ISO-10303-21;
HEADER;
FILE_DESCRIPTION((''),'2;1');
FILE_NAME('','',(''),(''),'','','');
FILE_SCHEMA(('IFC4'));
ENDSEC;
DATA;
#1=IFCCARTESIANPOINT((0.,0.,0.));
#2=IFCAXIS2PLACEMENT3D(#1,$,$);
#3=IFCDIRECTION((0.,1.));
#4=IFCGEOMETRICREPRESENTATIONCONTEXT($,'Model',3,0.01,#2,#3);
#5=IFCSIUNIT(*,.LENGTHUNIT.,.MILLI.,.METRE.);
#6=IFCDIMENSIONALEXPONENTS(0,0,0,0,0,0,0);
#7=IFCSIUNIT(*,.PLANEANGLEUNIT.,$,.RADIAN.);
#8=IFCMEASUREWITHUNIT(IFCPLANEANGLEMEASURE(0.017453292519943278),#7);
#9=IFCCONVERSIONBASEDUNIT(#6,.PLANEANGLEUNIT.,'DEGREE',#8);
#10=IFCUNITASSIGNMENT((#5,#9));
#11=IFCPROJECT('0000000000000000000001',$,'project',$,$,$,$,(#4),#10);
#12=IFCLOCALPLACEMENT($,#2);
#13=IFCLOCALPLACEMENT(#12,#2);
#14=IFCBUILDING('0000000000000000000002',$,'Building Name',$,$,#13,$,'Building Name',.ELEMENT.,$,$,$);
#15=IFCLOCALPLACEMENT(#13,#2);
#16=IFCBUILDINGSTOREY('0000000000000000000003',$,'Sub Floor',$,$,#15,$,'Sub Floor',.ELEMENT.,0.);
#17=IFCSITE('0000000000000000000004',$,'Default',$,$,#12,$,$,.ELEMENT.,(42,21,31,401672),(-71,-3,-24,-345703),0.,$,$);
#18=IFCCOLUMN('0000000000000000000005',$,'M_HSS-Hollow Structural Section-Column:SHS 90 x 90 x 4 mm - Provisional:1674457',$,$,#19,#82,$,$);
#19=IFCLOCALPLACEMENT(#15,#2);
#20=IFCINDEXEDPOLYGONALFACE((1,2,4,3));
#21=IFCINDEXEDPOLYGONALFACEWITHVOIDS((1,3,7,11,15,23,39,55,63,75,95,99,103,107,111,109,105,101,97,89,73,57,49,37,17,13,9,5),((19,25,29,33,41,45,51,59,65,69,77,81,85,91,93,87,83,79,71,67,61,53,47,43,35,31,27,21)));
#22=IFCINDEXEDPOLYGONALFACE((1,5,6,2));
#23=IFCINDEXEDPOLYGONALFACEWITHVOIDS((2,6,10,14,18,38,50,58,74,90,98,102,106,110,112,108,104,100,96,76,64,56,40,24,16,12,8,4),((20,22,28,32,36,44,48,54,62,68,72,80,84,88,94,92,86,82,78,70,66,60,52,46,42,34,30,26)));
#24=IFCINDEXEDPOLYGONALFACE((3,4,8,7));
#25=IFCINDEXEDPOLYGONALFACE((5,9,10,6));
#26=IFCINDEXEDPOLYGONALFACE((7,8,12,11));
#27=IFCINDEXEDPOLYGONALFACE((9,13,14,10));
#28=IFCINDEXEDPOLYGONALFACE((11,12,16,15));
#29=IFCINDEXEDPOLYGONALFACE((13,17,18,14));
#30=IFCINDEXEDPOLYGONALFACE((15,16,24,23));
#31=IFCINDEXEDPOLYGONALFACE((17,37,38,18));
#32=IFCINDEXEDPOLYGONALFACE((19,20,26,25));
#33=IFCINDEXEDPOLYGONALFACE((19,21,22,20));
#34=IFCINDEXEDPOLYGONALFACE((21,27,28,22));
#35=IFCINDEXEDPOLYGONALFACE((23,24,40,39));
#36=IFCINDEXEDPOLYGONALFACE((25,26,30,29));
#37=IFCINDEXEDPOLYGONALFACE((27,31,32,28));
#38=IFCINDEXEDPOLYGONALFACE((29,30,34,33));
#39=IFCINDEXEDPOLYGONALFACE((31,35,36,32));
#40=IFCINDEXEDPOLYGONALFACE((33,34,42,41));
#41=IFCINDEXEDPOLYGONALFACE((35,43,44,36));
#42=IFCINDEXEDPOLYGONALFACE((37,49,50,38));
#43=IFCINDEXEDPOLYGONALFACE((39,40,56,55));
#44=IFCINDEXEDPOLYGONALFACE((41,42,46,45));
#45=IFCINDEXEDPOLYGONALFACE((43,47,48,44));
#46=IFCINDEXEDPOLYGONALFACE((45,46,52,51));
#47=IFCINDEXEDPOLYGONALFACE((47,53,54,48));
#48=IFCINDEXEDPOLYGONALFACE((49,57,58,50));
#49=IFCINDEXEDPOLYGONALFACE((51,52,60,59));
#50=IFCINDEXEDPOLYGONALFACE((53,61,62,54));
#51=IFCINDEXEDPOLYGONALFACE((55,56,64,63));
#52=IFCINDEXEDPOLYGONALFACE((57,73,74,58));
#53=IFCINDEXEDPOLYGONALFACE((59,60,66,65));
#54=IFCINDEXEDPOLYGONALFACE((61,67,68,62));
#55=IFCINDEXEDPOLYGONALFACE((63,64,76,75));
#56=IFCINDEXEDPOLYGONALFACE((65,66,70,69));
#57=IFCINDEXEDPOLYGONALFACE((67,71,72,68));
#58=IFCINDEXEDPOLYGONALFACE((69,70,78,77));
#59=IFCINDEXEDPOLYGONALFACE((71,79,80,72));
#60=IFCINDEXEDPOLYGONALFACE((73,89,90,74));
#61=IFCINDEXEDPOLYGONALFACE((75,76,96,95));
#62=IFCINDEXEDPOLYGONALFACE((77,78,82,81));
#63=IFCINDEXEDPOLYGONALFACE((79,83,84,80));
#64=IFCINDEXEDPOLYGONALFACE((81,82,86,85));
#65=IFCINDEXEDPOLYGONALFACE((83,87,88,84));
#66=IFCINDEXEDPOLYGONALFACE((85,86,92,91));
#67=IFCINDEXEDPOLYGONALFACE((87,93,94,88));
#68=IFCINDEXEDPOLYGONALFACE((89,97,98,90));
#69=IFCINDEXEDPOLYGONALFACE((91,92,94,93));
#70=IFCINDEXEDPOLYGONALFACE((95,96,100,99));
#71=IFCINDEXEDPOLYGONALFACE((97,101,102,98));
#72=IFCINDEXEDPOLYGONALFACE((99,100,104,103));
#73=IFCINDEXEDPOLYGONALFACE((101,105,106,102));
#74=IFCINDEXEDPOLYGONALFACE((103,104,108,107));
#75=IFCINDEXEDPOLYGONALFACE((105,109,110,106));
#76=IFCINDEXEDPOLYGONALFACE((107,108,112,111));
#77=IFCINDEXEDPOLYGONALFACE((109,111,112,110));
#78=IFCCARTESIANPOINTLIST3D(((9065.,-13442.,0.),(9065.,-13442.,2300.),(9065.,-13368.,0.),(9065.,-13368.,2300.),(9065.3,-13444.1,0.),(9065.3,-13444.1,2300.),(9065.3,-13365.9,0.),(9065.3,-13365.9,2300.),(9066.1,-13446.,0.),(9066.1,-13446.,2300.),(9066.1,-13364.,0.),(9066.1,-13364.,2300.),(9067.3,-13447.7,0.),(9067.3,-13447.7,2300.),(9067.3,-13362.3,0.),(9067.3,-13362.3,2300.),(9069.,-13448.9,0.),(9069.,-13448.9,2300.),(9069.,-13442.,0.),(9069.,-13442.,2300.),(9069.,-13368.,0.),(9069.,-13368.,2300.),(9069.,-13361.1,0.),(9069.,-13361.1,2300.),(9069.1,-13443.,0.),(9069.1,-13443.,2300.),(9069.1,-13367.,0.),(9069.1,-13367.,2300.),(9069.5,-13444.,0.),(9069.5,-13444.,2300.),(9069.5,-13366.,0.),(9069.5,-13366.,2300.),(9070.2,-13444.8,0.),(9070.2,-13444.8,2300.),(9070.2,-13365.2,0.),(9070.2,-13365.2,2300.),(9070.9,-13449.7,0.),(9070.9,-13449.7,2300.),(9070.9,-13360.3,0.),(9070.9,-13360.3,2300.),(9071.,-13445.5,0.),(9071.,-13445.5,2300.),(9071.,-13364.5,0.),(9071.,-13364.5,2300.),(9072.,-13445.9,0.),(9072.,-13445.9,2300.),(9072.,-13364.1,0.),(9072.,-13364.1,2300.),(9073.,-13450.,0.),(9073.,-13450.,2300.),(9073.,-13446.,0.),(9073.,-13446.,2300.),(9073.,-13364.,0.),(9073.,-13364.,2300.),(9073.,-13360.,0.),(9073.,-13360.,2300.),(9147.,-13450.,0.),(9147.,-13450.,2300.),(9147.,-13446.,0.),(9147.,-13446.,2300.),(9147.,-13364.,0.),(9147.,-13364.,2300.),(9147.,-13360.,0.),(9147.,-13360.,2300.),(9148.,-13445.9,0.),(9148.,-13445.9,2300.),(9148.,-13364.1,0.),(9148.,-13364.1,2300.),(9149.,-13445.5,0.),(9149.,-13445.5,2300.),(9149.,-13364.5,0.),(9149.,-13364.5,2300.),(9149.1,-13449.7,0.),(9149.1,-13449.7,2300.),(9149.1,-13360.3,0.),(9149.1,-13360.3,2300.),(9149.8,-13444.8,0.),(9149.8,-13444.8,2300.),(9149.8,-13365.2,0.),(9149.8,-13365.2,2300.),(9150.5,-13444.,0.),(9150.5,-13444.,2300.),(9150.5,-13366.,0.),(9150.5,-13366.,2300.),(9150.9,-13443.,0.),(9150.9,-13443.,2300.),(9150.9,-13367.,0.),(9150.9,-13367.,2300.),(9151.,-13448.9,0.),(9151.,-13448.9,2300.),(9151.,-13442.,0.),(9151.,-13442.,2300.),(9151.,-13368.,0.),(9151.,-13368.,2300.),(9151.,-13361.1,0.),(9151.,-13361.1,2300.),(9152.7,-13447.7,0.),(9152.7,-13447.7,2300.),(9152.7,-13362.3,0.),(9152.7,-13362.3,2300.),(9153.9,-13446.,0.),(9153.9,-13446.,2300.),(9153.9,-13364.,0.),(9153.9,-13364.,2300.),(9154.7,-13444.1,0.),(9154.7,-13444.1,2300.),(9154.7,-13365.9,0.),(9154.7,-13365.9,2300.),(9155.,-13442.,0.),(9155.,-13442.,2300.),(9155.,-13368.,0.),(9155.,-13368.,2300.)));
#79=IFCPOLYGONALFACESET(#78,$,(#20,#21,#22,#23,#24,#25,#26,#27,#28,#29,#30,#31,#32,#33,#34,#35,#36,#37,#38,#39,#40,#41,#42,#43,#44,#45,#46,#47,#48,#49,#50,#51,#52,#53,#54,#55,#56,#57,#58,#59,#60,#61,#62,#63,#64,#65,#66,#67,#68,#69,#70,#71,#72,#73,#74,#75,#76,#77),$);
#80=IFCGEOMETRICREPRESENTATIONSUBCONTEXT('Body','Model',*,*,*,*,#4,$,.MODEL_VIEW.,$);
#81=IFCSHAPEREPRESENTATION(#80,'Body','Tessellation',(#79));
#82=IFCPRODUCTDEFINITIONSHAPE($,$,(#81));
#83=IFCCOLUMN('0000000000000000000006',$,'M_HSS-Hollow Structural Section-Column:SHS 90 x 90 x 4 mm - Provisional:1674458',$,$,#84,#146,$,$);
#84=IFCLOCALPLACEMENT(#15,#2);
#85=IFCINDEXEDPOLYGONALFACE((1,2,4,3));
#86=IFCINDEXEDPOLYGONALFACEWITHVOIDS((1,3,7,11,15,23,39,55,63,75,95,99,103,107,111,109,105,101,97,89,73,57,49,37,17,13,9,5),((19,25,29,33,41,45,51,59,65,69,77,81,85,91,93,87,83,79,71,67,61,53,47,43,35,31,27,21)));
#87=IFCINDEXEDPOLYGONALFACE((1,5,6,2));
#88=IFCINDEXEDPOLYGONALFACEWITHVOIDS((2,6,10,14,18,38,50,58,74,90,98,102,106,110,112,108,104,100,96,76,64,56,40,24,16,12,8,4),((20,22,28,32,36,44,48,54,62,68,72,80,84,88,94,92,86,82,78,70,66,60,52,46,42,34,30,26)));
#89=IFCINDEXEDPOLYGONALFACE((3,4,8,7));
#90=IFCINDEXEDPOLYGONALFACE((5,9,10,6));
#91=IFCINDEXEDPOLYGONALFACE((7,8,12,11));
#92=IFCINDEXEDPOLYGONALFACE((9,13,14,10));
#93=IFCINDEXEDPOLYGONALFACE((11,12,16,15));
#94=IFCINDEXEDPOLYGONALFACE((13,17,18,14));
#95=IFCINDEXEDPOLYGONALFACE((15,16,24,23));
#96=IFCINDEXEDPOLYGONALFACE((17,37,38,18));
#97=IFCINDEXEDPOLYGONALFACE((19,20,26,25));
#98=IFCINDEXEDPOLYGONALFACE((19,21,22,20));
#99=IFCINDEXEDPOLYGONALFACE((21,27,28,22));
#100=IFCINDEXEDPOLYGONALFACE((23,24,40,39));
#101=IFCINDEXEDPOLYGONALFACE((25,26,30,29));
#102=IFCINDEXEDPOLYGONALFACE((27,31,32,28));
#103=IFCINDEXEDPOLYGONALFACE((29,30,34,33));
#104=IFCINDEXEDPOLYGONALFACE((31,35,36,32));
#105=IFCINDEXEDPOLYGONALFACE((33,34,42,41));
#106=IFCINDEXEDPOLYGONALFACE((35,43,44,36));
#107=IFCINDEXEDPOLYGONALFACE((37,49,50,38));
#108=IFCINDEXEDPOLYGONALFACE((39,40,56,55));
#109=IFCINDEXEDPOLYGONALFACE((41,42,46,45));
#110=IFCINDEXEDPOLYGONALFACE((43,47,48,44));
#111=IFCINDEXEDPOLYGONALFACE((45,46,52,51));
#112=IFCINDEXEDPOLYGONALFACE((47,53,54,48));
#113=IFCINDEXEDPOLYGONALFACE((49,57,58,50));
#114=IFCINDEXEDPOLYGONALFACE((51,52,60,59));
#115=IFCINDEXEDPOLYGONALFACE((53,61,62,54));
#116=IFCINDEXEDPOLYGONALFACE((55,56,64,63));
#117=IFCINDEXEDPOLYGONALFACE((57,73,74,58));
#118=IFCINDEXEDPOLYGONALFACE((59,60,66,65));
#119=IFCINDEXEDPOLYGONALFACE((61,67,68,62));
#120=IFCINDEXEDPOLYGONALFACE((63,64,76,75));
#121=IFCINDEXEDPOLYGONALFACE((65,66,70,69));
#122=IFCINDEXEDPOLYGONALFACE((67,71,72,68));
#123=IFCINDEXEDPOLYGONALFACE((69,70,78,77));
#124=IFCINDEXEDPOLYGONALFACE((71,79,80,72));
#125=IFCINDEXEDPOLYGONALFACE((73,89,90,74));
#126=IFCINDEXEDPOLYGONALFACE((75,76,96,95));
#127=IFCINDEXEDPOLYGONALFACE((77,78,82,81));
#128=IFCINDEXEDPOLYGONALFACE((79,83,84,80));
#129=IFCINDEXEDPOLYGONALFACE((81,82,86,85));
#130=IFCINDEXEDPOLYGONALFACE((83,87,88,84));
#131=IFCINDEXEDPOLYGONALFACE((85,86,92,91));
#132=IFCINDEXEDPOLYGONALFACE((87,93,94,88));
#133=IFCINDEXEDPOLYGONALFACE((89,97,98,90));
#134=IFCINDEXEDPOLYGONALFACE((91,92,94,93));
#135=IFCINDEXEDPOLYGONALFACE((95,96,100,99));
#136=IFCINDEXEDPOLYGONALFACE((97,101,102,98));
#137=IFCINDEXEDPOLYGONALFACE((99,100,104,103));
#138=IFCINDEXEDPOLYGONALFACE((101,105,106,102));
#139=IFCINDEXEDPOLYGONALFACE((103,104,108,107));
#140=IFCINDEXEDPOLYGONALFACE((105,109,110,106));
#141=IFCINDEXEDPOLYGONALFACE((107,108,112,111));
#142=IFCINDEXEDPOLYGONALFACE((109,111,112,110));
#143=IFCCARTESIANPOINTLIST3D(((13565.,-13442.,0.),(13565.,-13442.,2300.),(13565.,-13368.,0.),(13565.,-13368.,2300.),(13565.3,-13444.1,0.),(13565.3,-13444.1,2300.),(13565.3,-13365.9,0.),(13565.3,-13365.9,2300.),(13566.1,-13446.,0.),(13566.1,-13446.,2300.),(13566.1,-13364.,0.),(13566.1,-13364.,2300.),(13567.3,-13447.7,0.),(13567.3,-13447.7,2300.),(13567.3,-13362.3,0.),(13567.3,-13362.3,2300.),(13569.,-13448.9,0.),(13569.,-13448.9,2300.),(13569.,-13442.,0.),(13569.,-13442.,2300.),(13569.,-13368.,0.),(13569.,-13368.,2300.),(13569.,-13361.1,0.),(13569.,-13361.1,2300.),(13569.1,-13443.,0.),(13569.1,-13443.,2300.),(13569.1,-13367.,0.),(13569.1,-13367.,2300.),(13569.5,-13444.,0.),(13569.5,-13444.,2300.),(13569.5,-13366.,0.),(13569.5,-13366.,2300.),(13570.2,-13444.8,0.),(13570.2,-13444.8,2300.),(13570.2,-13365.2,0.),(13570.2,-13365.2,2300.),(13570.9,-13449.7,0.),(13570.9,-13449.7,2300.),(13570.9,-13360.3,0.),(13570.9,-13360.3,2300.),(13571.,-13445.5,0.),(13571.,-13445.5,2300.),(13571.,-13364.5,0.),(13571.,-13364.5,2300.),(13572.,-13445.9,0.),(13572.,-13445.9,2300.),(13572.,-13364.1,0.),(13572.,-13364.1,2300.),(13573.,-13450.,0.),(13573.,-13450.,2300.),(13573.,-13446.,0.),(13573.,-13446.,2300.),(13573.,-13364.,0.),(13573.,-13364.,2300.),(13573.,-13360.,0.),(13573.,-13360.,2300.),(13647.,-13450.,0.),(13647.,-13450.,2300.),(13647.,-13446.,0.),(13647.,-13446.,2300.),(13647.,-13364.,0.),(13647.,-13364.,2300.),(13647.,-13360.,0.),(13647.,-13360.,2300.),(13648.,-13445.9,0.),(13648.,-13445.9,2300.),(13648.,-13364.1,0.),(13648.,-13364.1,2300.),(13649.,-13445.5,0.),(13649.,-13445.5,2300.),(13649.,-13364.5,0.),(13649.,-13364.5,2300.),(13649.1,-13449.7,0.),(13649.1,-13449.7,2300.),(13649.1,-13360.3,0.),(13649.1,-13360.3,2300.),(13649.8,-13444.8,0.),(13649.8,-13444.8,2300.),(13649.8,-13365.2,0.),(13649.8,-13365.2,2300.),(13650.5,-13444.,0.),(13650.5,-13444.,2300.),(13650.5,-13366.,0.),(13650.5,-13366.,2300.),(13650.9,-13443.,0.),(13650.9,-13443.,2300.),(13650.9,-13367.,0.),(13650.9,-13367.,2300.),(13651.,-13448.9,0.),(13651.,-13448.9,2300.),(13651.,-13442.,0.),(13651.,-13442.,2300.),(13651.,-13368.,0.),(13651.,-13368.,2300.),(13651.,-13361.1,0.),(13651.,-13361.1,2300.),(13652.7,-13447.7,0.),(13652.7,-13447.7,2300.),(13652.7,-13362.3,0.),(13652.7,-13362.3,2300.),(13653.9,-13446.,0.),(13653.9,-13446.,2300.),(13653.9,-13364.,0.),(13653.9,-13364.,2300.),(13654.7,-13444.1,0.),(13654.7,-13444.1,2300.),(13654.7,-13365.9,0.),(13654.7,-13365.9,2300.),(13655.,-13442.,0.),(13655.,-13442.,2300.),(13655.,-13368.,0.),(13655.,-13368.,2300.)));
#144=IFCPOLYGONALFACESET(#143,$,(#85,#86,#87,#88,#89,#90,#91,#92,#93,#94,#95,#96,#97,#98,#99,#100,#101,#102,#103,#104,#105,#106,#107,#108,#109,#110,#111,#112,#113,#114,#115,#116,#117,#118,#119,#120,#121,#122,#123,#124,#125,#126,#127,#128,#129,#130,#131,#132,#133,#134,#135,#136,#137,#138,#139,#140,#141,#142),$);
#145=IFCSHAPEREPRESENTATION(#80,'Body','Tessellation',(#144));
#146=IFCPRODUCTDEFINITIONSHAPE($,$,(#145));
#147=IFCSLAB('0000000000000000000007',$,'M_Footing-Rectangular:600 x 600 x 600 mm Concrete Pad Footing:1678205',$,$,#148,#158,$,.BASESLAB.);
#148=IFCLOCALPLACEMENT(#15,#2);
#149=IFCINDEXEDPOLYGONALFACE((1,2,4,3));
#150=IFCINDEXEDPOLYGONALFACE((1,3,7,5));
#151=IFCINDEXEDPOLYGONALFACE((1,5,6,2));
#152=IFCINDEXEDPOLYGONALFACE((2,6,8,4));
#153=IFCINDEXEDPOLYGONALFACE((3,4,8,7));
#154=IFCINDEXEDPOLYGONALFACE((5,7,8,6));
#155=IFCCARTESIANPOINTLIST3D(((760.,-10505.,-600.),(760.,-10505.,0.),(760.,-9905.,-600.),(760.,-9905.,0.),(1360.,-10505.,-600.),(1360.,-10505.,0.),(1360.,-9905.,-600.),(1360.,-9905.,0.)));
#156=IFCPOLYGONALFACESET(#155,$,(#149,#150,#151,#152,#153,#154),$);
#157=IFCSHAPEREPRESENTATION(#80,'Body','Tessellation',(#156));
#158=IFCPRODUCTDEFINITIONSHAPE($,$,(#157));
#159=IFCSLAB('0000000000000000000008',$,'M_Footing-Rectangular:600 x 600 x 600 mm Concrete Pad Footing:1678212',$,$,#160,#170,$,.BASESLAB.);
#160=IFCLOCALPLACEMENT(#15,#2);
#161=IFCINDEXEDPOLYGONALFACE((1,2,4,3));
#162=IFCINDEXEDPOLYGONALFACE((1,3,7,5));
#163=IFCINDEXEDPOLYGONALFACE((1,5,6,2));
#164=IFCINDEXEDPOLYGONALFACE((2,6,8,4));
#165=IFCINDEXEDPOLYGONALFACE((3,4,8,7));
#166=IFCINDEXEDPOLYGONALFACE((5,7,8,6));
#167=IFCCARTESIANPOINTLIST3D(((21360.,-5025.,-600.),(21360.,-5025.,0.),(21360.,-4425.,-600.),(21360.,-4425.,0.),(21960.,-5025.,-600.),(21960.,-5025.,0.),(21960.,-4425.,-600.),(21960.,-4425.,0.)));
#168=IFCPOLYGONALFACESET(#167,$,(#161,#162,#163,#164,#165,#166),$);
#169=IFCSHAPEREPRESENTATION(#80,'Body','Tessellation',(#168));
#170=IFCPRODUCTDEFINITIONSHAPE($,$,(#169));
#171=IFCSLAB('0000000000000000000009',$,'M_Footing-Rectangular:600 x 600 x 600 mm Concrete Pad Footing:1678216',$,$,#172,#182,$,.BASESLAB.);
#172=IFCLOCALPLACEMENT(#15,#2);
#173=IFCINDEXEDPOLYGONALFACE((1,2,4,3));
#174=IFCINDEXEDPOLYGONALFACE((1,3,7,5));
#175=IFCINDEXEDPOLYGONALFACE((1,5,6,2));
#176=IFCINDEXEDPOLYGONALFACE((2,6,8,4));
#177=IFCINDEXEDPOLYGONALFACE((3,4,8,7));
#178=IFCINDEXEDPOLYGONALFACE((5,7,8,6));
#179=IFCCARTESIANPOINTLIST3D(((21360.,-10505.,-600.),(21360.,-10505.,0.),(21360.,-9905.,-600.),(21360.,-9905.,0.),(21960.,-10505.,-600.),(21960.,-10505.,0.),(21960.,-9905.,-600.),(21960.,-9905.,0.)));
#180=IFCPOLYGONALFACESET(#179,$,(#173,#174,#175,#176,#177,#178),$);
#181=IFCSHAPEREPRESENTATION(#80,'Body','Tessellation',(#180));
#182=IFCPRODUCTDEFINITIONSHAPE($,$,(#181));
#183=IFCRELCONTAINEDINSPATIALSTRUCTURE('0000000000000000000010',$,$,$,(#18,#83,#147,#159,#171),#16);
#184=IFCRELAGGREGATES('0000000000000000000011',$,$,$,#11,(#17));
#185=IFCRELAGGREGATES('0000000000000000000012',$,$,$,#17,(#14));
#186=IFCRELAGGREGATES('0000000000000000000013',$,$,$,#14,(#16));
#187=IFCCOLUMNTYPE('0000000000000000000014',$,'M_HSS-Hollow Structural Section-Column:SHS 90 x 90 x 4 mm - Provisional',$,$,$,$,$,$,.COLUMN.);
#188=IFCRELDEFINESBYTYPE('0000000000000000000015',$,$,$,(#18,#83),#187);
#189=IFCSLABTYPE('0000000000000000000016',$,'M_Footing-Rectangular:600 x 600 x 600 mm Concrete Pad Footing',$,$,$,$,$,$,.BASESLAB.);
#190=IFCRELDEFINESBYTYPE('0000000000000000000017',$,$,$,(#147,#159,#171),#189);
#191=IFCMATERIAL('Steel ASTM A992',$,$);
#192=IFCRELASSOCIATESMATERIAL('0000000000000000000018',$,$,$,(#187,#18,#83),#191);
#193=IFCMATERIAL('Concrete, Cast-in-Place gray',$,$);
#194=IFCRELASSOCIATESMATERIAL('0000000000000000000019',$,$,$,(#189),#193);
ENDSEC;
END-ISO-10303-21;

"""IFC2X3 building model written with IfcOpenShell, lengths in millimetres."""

from ifc_helpers import new_model, entity, si_unit, converted_unit, direction, frame, frame_2d, origin, place, context, subcontext, project, spatial, polyline, circle_curve, parameter, trimmed, segment, composite_curve, rectangle, outline, extrude, source, transform, mapped, material, type_object, type_shapes, element, save


model = new_model("IFC2X3")

# Units and contexts
model_context = context("Model", 3, precision=0.01, world=origin(), true_north=direction((0.0, 1.0)))
body_context = subcontext(model_context, "Body", "Model", "MODEL_VIEW")
ifc_project = project(units=[si_unit("LENGTHUNIT", "METRE", prefix="MILLI"), converted_unit("PLANEANGLEUNIT", "DEGREE", entity("IfcPlaneAngleMeasure", 0.017453292519943278), si_unit("PLANEANGLEUNIT", "RADIAN"), dimensions=[0, 0, 0, 0, 0, 0, 0])], contexts=[model_context])

# Site, building, storey
site_placement = place(None, origin())
site = spatial("IfcSite", under=ifc_project, at=site_placement, Name="Default", CompositionType="ELEMENT", RefLatitude=(42, 21, 31, 401672), RefLongitude=(-71, -3, -24, -345703), RefElevation=0.0)
building_placement = place(site_placement, origin())
building = spatial("IfcBuilding", under=site, at=building_placement, Name="Building Name", LongName="Building Name", CompositionType="ELEMENT")
storey_placement = place(building_placement, origin())
storey = spatial("IfcBuildingStorey", under=building, at=storey_placement, Name="Sub Floor", LongName="Sub Floor", CompositionType="ELEMENT", Elevation=0.0)

# Columns
ifc_material_1 = material(Name="Steel ASTM A992")
column_type = type_object("IfcColumnType", Name="M_HSS-Hollow Structural Section-Column:SHS 90 x 90 x 4 mm - Provisional", PredefinedType="COLUMN", material=ifc_material_1)
shared_shape_1 = source(origin(), body_context, "Body", "SweptSolid", [
    extrude(outline(composite_curve([segment(polyline([(-37.0, -45.0), (37.0, -45.0)]), True, "CONTINUOUS"), segment(trimmed(circle_curve(frame_2d((37.0, -37.0), x_axis=(-1.0, 0.0)), 8.0), [parameter(90.0)], [parameter(180.0)], True, "PARAMETER"), True, "CONTINUOUS"), segment(polyline([(45.0, -37.0), (45.0, 37.0)]), True, "CONTINUOUS"), segment(trimmed(circle_curve(frame_2d((37.0, 37.0), x_axis=(-1.0, 0.0)), 8.0), [parameter(180.0)], [parameter(270.0)], True, "PARAMETER"), True, "CONTINUOUS"), segment(polyline([(37.0, 45.0), (-37.0, 45.0)]), True, "CONTINUOUS"), segment(trimmed(circle_curve(frame_2d((-37.0, 37.0), x_axis=(-1.0, 0.0)), 8.0), [parameter(270.0)], [parameter(360.0)], True, "PARAMETER"), True, "CONTINUOUS"), segment(polyline([(-45.0, 37.0), (-45.0, -37.0)]), True, "CONTINUOUS"), segment(trimmed(circle_curve(frame_2d((-37.0, -37.0), x_axis=(-1.0, 0.0)), 8.0), [parameter(360.0)], [parameter(90.0)], True, "PARAMETER"), True, "CONTINUOUS")], self_intersect=False), holes=[composite_curve([segment(trimmed(circle_curve(frame_2d((-37.0, -37.0), x_axis=(-1.0, 0.0)), 4.0), [parameter(0.0)], [parameter(90.0)], True, "PARAMETER"), False, "CONTINUOUS"), segment(polyline([(-41.0, -37.0), (-41.0, 37.0)]), True, "CONTINUOUS"), segment(trimmed(circle_curve(frame_2d((-37.0, 37.0), x_axis=(-1.0, 0.0)), 4.0), [parameter(270.0)], [parameter(0.0)], True, "PARAMETER"), False, "CONTINUOUS"), segment(polyline([(-37.0, 41.0), (37.0, 41.0)]), True, "CONTINUOUS"), segment(trimmed(circle_curve(frame_2d((37.0, 37.0), x_axis=(-1.0, 0.0)), 4.0), [parameter(180.0)], [parameter(270.0)], True, "PARAMETER"), False, "CONTINUOUS"), segment(polyline([(41.0, 37.0), (41.0, -37.0)]), True, "CONTINUOUS"), segment(trimmed(circle_curve(frame_2d((37.0, -37.0), x_axis=(-1.0, 0.0)), 4.0), [parameter(90.0)], [parameter(180.0)], True, "PARAMETER"), False, "CONTINUOUS"), segment(polyline([(37.0, -41.0), (-37.0, -41.0)]), True, "CONTINUOUS")], self_intersect=False)]), frame((0.0, 0.0, 0.0), z_axis=(0.0, 0.0, 1.0), x_axis=(-1.0, 0.0, 0.0)), (0.0, 0.0, 1.0), 2300.0),
])
type_shapes(column_type, [shared_shape_1])
for number, where, name in (
    (1, (9110.0, -13405.0, 0.0), "M_HSS-Hollow Structural Section-Column:SHS 90 x 90 x 4 mm - Provisional:1674457"),
    (2, (13610.0, -13405.0, 0.0), "M_HSS-Hollow Structural Section-Column:SHS 90 x 90 x 4 mm - Provisional:1674458"),
):
    element("IfcColumn", number, at=place(storey_placement, frame(where)), inside=storey, type_object=column_type, material=ifc_material_1, Name=name, context=body_context, shape_type="MappedRepresentation", body=[
        mapped(shared_shape_1, transform((0.0, 0.0, 0.0), scale=1.0)),
    ])

# Slabs
ifc_material_2 = material(Name="Concrete, Cast-in-Place gray")
slab_type = type_object("IfcSlabType", Name="M_Footing-Rectangular:600 x 600 x 600 mm Concrete Pad Footing", PredefinedType="BASESLAB", material=ifc_material_2)
slab_1_placement = place(storey_placement, origin())
element("IfcSlab", 3, at=slab_1_placement, inside=storey, type_object=slab_type, Name="M_Footing-Rectangular:600 x 600 x 600 mm Concrete Pad Footing:1678205", PredefinedType="BASESLAB", context=body_context, shape_type="SweptSolid", body=[
    extrude(rectangle(XDim=600.0, YDim=600.0, at=frame_2d((0.0, 0.0), x_axis=(1.0, 0.0))), frame((1060.0, -10205.0, -600.0), z_axis=(0.0, 0.0, 1.0), x_axis=(-1.0, 0.0, 0.0)), (0.0, 0.0, 1.0), 600.0),
])
slab_2_placement = place(storey_placement, origin())
element("IfcSlab", 4, at=slab_2_placement, inside=storey, type_object=slab_type, Name="M_Footing-Rectangular:600 x 600 x 600 mm Concrete Pad Footing:1678212", PredefinedType="BASESLAB", context=body_context, shape_type="SweptSolid", body=[
    extrude(rectangle(XDim=600.0, YDim=600.0, at=frame_2d((0.0, 0.0), x_axis=(1.0, 0.0))), frame((21660.0, -4725.0, -600.0), z_axis=(0.0, 0.0, 1.0), x_axis=(-1.0, 0.0, 0.0)), (0.0, 0.0, 1.0), 600.0),
])
slab_3_placement = place(storey_placement, origin())
element("IfcSlab", 5, at=slab_3_placement, inside=storey, type_object=slab_type, Name="M_Footing-Rectangular:600 x 600 x 600 mm Concrete Pad Footing:1678216", PredefinedType="BASESLAB", context=body_context, shape_type="SweptSolid", body=[
    extrude(rectangle(XDim=600.0, YDim=600.0, at=frame_2d((0.0, 0.0), x_axis=(1.0, 0.0))), frame((21660.0, -10205.0, -600.0), z_axis=(0.0, 0.0, 1.0), x_axis=(-1.0, 0.0, 0.0)), (0.0, 0.0, 1.0), 600.0),
])

save(model, "model.ifc")
